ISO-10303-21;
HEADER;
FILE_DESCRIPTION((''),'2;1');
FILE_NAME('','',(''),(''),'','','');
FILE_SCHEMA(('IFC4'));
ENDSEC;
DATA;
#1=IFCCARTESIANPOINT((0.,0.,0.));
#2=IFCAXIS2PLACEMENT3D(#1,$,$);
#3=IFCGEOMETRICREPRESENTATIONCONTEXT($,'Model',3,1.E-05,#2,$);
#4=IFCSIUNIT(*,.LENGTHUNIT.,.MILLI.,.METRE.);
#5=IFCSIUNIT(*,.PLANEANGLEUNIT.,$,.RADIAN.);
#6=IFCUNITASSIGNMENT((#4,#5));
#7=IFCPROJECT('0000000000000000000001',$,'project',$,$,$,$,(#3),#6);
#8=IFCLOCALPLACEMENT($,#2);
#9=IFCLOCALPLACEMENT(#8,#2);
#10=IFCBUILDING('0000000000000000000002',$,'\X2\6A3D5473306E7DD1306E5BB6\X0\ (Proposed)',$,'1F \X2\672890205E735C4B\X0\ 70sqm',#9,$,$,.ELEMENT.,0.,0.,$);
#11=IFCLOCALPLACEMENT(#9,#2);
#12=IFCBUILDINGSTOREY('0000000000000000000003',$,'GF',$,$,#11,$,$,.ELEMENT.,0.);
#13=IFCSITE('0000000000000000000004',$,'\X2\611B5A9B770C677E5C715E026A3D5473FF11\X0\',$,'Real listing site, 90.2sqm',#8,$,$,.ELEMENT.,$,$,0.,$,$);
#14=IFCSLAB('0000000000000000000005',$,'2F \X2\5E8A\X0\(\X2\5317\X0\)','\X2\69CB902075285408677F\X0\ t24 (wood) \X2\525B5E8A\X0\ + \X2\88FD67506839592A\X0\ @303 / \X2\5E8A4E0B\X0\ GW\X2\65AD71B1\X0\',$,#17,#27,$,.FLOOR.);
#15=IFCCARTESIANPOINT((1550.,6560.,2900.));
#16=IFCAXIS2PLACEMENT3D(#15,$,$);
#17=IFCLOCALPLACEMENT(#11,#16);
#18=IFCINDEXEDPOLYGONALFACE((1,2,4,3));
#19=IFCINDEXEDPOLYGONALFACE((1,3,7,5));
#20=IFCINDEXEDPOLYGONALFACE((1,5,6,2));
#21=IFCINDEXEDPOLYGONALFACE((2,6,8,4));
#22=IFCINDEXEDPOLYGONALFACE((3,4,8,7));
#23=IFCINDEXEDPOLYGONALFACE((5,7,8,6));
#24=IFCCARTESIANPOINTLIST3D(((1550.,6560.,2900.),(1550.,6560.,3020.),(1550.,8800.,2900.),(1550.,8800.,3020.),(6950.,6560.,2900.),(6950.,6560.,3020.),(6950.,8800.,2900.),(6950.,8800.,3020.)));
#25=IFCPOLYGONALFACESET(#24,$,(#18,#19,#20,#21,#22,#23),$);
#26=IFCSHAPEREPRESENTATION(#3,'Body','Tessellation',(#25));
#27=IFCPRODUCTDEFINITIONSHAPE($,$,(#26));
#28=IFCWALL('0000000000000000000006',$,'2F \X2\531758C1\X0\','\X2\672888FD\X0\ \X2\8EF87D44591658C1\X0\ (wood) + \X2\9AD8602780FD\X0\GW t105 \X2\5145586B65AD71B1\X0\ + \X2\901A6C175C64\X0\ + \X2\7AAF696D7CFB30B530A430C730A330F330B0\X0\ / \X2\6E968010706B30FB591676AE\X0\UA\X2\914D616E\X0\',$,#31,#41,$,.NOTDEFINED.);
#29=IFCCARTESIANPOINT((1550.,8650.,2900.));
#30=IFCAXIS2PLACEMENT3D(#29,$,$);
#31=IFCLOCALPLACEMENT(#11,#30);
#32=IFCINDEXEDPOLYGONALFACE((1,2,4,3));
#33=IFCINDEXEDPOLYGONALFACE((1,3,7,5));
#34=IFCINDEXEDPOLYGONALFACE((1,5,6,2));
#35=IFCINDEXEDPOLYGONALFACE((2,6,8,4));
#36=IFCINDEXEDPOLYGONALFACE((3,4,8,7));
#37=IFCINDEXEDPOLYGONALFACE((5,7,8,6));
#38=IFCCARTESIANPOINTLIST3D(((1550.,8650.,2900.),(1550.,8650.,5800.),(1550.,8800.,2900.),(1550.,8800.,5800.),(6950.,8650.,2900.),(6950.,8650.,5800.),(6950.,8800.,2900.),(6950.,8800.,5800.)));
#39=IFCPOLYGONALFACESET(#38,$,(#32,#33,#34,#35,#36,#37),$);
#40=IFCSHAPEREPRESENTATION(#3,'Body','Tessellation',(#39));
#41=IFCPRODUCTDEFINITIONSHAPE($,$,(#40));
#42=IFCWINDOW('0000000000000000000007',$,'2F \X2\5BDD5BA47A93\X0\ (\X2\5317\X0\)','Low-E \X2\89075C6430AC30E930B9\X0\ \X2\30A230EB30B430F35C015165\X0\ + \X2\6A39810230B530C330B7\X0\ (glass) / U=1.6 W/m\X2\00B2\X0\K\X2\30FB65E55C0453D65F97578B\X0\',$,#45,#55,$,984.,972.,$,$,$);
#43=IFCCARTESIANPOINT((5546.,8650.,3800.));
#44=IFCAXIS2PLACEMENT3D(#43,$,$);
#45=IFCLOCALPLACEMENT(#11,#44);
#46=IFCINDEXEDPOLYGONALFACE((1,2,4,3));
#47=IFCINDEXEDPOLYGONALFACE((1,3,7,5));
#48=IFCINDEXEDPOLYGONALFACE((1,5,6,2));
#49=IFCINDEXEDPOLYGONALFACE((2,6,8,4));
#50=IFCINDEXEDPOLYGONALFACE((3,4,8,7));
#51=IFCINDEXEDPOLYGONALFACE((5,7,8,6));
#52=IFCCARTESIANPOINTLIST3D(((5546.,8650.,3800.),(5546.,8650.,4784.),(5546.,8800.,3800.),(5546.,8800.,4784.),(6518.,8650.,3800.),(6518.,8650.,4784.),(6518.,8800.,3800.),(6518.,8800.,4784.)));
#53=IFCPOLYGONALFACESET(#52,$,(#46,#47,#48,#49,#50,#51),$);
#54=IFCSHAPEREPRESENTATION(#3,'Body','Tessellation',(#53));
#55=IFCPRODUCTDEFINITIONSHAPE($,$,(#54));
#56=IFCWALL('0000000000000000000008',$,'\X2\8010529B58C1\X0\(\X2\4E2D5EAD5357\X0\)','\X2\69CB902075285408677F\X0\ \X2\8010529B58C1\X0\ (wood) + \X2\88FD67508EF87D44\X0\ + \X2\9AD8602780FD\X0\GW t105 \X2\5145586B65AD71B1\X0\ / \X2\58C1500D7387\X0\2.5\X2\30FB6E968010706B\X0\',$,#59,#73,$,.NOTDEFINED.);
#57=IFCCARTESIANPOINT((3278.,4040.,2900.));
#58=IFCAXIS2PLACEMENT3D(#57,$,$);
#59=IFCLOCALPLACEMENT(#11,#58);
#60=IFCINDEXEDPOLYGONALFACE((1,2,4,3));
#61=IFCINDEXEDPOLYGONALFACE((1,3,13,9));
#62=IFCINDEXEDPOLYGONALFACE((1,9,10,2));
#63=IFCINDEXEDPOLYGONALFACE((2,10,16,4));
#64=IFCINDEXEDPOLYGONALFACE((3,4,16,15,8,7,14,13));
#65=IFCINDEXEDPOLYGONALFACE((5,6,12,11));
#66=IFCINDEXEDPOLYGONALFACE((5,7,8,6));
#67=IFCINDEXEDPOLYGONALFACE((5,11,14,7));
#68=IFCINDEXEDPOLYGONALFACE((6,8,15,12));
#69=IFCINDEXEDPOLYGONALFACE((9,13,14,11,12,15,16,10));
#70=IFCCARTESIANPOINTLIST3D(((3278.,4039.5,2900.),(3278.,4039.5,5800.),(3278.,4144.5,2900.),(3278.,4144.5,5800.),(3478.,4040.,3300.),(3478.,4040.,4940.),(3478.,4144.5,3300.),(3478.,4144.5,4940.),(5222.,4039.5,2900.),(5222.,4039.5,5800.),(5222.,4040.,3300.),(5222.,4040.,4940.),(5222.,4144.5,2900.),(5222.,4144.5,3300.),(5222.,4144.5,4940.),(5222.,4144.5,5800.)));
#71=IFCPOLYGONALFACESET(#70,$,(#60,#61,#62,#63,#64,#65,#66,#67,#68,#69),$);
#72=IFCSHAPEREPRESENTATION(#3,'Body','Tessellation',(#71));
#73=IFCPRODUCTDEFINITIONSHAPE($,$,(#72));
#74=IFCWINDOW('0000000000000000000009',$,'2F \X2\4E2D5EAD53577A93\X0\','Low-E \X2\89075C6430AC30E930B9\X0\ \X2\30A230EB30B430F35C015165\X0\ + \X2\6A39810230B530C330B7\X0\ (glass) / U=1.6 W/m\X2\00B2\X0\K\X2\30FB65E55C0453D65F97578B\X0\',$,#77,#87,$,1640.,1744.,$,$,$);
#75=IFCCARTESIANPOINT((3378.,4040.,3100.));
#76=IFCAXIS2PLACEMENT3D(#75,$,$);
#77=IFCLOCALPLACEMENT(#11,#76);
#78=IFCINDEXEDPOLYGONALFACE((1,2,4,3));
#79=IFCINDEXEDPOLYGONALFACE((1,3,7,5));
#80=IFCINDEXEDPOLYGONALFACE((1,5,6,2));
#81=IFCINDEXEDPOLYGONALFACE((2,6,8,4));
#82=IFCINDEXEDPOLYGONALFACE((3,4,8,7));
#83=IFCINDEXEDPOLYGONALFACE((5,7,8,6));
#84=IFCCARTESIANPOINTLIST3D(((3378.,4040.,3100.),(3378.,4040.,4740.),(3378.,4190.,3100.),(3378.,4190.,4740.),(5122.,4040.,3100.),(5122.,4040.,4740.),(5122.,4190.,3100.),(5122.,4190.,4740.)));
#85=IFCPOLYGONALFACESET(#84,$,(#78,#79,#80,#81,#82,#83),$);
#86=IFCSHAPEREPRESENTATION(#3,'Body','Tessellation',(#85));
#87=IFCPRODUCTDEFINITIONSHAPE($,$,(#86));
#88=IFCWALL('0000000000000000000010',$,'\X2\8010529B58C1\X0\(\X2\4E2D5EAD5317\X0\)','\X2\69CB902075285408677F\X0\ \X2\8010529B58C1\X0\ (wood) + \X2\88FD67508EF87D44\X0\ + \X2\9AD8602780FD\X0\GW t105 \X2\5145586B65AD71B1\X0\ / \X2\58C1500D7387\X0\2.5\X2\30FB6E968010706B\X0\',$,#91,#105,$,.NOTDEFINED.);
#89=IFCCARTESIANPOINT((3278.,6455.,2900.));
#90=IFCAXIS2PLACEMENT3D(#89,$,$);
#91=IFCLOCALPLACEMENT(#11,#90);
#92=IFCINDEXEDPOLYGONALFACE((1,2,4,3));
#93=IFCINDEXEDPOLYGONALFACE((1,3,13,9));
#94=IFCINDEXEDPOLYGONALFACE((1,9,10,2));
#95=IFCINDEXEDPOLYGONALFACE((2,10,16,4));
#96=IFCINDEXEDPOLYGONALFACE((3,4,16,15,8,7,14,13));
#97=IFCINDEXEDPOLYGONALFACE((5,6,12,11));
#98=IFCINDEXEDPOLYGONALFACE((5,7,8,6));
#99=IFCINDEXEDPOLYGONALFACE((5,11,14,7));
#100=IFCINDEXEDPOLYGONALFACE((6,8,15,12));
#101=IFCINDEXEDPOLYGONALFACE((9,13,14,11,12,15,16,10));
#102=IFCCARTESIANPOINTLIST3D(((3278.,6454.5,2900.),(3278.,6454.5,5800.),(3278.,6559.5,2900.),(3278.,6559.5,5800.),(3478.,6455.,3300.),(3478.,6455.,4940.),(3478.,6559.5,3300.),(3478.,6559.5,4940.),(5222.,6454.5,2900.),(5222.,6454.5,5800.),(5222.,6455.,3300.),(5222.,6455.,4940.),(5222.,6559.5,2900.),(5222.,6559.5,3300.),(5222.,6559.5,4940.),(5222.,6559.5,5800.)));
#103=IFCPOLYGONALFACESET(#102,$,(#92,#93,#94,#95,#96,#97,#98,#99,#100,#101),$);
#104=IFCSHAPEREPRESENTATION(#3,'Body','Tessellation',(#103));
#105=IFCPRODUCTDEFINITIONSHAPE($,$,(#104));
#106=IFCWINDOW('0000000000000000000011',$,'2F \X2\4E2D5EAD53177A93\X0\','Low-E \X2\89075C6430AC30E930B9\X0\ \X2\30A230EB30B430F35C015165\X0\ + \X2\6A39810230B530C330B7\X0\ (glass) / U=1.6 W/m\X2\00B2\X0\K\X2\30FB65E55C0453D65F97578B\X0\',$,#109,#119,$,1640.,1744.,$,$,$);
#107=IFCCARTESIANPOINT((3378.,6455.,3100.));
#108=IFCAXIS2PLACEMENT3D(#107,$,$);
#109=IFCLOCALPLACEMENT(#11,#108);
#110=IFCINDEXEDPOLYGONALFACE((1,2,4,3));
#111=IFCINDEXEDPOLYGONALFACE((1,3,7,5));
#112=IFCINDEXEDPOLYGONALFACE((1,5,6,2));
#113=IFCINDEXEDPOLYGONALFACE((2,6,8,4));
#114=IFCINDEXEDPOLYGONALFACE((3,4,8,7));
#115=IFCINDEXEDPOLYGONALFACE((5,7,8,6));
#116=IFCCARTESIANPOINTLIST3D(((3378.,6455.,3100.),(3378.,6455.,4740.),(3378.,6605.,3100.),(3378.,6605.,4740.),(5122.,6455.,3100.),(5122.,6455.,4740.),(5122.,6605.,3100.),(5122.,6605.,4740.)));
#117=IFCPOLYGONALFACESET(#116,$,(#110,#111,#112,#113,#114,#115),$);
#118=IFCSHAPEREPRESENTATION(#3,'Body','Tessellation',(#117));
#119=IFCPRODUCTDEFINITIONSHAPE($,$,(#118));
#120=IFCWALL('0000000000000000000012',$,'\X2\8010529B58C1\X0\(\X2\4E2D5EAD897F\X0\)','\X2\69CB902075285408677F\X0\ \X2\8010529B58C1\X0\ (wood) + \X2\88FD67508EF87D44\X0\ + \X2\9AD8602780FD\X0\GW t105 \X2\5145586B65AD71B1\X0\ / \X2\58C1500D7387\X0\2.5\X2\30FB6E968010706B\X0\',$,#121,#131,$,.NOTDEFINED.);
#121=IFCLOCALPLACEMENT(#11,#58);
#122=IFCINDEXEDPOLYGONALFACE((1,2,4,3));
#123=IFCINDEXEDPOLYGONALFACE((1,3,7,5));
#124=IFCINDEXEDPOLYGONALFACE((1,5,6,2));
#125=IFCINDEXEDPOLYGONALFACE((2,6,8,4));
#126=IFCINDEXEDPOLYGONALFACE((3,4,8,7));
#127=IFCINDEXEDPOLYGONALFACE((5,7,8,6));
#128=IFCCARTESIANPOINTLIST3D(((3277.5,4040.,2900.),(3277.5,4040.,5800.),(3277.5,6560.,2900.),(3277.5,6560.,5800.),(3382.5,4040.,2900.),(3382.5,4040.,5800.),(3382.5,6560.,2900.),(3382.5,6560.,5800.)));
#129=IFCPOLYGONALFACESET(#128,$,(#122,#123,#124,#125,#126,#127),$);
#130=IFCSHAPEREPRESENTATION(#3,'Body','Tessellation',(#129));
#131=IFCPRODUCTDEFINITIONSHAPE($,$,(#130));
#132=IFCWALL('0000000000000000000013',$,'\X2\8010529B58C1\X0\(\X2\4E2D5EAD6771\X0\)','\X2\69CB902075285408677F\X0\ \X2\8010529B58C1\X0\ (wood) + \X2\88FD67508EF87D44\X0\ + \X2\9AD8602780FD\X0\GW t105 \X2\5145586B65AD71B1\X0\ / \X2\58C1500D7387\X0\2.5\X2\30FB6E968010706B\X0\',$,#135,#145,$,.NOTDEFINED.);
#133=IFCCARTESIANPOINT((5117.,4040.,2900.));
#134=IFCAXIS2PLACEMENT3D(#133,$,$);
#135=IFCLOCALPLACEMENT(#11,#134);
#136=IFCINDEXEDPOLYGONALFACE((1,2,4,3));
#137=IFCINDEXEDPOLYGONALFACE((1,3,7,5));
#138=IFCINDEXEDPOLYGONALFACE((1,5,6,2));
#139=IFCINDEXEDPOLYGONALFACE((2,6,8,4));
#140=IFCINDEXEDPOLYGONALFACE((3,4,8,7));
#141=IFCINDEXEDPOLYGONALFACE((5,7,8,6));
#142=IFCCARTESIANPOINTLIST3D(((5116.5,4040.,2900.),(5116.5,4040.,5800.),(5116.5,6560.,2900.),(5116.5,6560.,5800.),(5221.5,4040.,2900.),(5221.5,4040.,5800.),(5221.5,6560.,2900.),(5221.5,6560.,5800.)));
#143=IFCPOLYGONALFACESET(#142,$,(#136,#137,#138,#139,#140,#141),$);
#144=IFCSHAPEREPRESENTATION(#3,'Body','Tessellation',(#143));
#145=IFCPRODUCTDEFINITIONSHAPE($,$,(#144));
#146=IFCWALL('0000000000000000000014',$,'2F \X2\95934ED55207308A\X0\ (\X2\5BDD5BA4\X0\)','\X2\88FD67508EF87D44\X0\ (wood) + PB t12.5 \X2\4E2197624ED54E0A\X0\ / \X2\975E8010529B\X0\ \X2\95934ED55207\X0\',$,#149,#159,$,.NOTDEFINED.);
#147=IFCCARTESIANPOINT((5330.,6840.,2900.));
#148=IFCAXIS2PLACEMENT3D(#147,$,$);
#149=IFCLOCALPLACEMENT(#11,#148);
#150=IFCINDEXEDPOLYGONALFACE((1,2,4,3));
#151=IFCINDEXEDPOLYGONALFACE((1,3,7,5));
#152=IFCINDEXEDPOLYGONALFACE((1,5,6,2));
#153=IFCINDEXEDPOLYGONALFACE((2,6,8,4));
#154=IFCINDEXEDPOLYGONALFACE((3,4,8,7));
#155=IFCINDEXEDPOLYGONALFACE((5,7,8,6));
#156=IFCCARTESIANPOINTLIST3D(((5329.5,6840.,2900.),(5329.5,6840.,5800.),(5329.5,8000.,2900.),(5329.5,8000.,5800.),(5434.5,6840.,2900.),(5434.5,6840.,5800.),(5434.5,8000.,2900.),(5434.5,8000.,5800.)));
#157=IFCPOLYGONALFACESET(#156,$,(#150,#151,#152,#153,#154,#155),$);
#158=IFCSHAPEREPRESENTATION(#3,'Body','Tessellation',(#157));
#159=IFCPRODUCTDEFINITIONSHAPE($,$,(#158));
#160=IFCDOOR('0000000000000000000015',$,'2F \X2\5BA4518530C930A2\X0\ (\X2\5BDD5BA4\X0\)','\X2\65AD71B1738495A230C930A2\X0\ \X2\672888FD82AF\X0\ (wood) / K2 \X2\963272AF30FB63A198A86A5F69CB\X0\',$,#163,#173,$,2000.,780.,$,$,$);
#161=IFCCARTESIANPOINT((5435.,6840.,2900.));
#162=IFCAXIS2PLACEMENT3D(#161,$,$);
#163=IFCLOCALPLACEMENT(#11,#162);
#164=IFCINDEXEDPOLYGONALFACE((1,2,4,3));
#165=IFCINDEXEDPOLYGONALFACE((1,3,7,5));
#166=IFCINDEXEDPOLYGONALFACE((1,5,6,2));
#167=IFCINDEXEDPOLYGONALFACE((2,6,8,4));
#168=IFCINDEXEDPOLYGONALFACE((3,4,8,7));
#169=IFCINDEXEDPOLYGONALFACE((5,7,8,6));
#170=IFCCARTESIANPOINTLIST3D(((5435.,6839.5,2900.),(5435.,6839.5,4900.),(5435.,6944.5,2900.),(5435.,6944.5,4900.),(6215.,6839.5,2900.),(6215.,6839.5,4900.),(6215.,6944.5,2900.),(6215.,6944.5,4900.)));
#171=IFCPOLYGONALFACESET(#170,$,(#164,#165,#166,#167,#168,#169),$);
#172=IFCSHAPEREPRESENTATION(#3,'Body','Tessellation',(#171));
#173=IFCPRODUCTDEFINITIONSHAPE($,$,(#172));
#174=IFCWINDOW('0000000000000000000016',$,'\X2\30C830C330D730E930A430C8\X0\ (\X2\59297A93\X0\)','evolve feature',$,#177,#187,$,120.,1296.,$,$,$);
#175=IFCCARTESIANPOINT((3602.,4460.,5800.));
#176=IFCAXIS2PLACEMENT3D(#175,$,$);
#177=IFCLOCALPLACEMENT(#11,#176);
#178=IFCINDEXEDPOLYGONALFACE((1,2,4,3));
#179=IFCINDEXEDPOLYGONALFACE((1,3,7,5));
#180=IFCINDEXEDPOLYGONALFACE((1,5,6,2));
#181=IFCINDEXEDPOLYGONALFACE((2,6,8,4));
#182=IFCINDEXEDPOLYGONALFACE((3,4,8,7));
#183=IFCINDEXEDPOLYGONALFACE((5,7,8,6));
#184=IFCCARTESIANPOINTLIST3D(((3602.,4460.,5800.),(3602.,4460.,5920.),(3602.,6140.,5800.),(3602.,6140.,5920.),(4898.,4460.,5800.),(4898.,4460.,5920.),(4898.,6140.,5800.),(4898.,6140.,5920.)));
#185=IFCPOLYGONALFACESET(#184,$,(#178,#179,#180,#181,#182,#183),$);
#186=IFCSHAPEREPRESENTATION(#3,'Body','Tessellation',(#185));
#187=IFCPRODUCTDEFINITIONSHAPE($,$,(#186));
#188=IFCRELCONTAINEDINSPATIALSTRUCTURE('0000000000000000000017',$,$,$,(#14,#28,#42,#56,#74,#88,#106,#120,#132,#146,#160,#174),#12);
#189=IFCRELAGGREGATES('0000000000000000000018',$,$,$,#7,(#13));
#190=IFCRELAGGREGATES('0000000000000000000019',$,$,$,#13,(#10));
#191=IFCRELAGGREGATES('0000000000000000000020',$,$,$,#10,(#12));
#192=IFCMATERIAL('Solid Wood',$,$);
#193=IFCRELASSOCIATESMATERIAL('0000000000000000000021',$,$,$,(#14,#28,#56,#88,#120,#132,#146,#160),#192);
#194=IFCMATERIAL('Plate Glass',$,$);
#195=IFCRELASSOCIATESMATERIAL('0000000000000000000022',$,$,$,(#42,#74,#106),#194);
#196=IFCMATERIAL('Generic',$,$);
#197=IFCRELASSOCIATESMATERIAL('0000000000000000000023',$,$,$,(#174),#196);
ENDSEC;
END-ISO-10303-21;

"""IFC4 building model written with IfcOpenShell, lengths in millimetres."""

from ifc_helpers import new_model, si_unit, frame, frame_2d, origin, place, context, project, spatial, rectangle, extrude, material, element, fill, save


model = new_model("IFC4")

# Units and contexts
model_context = context("Model", 3, precision=1e-05, world=origin())
ifc_project = project(units=[si_unit("LENGTHUNIT", "METRE", prefix="MILLI"), si_unit("PLANEANGLEUNIT", "RADIAN")], contexts=[model_context])

# Site, building, storey
site_placement = place(None, origin())
site = spatial("IfcSite", under=ifc_project, at=site_placement, Name="愛媛県松山市樽味１", ObjectType="Real listing site, 90.2sqm", CompositionType="ELEMENT", RefElevation=0.0)
building_placement = place(site_placement, origin())
building = spatial("IfcBuilding", under=site, at=building_placement, Name="樽味の緑の家 (Proposed)", ObjectType="1F 木造平屋 70sqm", CompositionType="ELEMENT", ElevationOfRefHeight=0.0, ElevationOfTerrain=0.0)
storey_placement = place(building_placement, origin())
storey = spatial("IfcBuildingStorey", under=building, at=storey_placement, Name="GF", CompositionType="ELEMENT", Elevation=0.0)

# Slab
ifc_material_1 = material(Name="Solid Wood")
slab_placement = place(storey_placement, frame((1550.0, 6560.0, 2900.0)))
element("IfcSlab", 1, at=slab_placement, inside=storey, material=ifc_material_1, Name="2F 床(北)", Description="構造用合板 t24 (wood) 剛床 + 製材根太 @303 / 床下 GW断熱", PredefinedType="FLOOR", context=model_context, shape_type="SweptSolid", body=[
    extrude(rectangle(XDim=5400.0, YDim=2240.0, at=frame_2d((2700.0, 1120.0))), frame((1550.0, 6560.0, 2900.0)), (0.0, 0.0, 1.0), 120.0),
])

# Walls, openings, windows
wall_1_placement = place(storey_placement, frame((1550.0, 8650.0, 2900.0)))
wall_1 = element("IfcWall", 2, at=wall_1_placement, inside=storey, material=ifc_material_1, Name="2F 北壁", Description="木製 軸組外壁 (wood) + 高性能GW t105 充填断熱 + 通気層 + 窯業系サイディング / 準耐火・外皮UA配慮", PredefinedType="NOTDEFINED", context=model_context, shape_type="SweptSolid", body=[
    extrude(rectangle(XDim=5400.0, YDim=150.0, at=frame_2d((2700.0, 75.0))), frame((1550.0, 8650.0, 2900.0)), (0.0, 0.0, 1.0), 2900.0),
])
opening_1_placement = place(storey_placement, frame((5546.0, 8650.0, 3800.0)))
opening_1 = element("IfcOpeningElement", 3, at=opening_1_placement, cuts=wall_1, PredefinedType="NOTDEFINED", context=model_context, shape_type="SweptSolid", body=[
    extrude(rectangle(XDim=972.0, YDim=150.0, at=frame_2d((486.0, 75.0))), frame((5546.0, 8650.0, 3800.0)), (0.0, 0.0, 1.0), 984.0),
])
ifc_material_2 = material(Name="Plate Glass")
window_1_placement = place(storey_placement, frame((5546.0, 8650.0, 3800.0)))
window_1 = element("IfcWindow", 4, at=window_1_placement, inside=storey, material=ifc_material_2, Name="2F 寝室窓 (北)", Description="Low-E 複層ガラス アルゴン封入 + 樹脂サッシ (glass) / U=1.6 W/m²K・日射取得型", OverallHeight=984.0, OverallWidth=972.0, context=model_context, shape_type="SweptSolid", body=[
    extrude(rectangle(XDim=972.0, YDim=150.0, at=frame_2d((486.0, 75.0))), frame((5546.0, 8650.0, 3800.0)), (0.0, 0.0, 1.0), 984.0),
])
fill(opening_1, window_1)
wall_2_placement = place(storey_placement, frame((3278.0, 4040.0, 2900.0)))
wall_2 = element("IfcWall", 5, at=wall_2_placement, inside=storey, material=ifc_material_1, Name="耐力壁(中庭南)", Description="構造用合板 耐力壁 (wood) + 製材軸組 + 高性能GW t105 充填断熱 / 壁倍率2.5・準耐火", PredefinedType="NOTDEFINED", context=model_context, shape_type="SweptSolid", body=[
    extrude(rectangle(XDim=1944.0, YDim=105.0, at=frame_2d((972.0, 52.0))), frame((3278.0, 4040.0, 2900.0)), (0.0, 0.0, 1.0), 2900.0),
])
opening_2_placement = place(storey_placement, frame((3378.0, 4040.0, 3100.0)))
opening_2 = element("IfcOpeningElement", 6, at=opening_2_placement, cuts=wall_2, PredefinedType="NOTDEFINED", context=model_context, shape_type="SweptSolid", body=[
    extrude(rectangle(XDim=1744.0, YDim=150.0, at=frame_2d((872.0, 75.0))), frame((3378.0, 4040.0, 3100.0)), (0.0, 0.0, 1.0), 1640.0),
])
window_2_placement = place(storey_placement, frame((3378.0, 4040.0, 3100.0)))
window_2 = element("IfcWindow", 7, at=window_2_placement, inside=storey, material=ifc_material_2, Name="2F 中庭南窓", Description="Low-E 複層ガラス アルゴン封入 + 樹脂サッシ (glass) / U=1.6 W/m²K・日射取得型", OverallHeight=1640.0, OverallWidth=1744.0, context=model_context, shape_type="SweptSolid", body=[
    extrude(rectangle(XDim=1744.0, YDim=150.0, at=frame_2d((872.0, 75.0))), frame((3378.0, 4040.0, 3100.0)), (0.0, 0.0, 1.0), 1640.0),
])
fill(opening_2, window_2)
wall_3_placement = place(storey_placement, frame((3278.0, 6455.0, 2900.0)))
wall_3 = element("IfcWall", 8, at=wall_3_placement, inside=storey, material=ifc_material_1, Name="耐力壁(中庭北)", Description="構造用合板 耐力壁 (wood) + 製材軸組 + 高性能GW t105 充填断熱 / 壁倍率2.5・準耐火", PredefinedType="NOTDEFINED", context=model_context, shape_type="SweptSolid", body=[
    extrude(rectangle(XDim=1944.0, YDim=105.0, at=frame_2d((972.0, 52.0))), frame((3278.0, 6455.0, 2900.0)), (0.0, 0.0, 1.0), 2900.0),
])
opening_3_placement = place(storey_placement, frame((3378.0, 6455.0, 3100.0)))
opening_3 = element("IfcOpeningElement", 9, at=opening_3_placement, cuts=wall_3, PredefinedType="NOTDEFINED", context=model_context, shape_type="SweptSolid", body=[
    extrude(rectangle(XDim=1744.0, YDim=150.0, at=frame_2d((872.0, 75.0))), frame((3378.0, 6455.0, 3100.0)), (0.0, 0.0, 1.0), 1640.0),
])
window_3_placement = place(storey_placement, frame((3378.0, 6455.0, 3100.0)))
window_3 = element("IfcWindow", 10, at=window_3_placement, inside=storey, material=ifc_material_2, Name="2F 中庭北窓", Description="Low-E 複層ガラス アルゴン封入 + 樹脂サッシ (glass) / U=1.6 W/m²K・日射取得型", OverallHeight=1640.0, OverallWidth=1744.0, context=model_context, shape_type="SweptSolid", body=[
    extrude(rectangle(XDim=1744.0, YDim=150.0, at=frame_2d((872.0, 75.0))), frame((3378.0, 6455.0, 3100.0)), (0.0, 0.0, 1.0), 1640.0),
])
fill(opening_3, window_3)

# Walls
wall_4_placement = place(storey_placement, frame((3278.0, 4040.0, 2900.0)))
element("IfcWall", 11, at=wall_4_placement, inside=storey, material=ifc_material_1, Name="耐力壁(中庭西)", Description="構造用合板 耐力壁 (wood) + 製材軸組 + 高性能GW t105 充填断熱 / 壁倍率2.5・準耐火", PredefinedType="NOTDEFINED", context=model_context, shape_type="SweptSolid", body=[
    extrude(rectangle(XDim=105.0, YDim=2520.0, at=frame_2d((52.0, 1260.0))), frame((3278.0, 4040.0, 2900.0)), (0.0, 0.0, 1.0), 2900.0),
])
wall_5_placement = place(storey_placement, frame((5117.0, 4040.0, 2900.0)))
element("IfcWall", 12, at=wall_5_placement, inside=storey, material=ifc_material_1, Name="耐力壁(中庭東)", Description="構造用合板 耐力壁 (wood) + 製材軸組 + 高性能GW t105 充填断熱 / 壁倍率2.5・準耐火", PredefinedType="NOTDEFINED", context=model_context, shape_type="SweptSolid", body=[
    extrude(rectangle(XDim=105.0, YDim=2520.0, at=frame_2d((52.0, 1260.0))), frame((5117.0, 4040.0, 2900.0)), (0.0, 0.0, 1.0), 2900.0),
])
wall_6_placement = place(storey_placement, frame((5330.0, 6840.0, 2900.0)))
element("IfcWall", 13, at=wall_6_placement, inside=storey, material=ifc_material_1, Name="2F 間仕切り (寝室)", Description="製材軸組 (wood) + PB t12.5 両面仕上 / 非耐力 間仕切", PredefinedType="NOTDEFINED", context=model_context, shape_type="SweptSolid", body=[
    extrude(rectangle(XDim=105.0, YDim=1160.0, at=frame_2d((52.0, 580.0))), frame((5330.0, 6840.0, 2900.0)), (0.0, 0.0, 1.0), 2900.0),
])

# Door
door_placement = place(storey_placement, frame((5435.0, 6840.0, 2900.0)))
element("IfcDoor", 14, at=door_placement, inside=storey, material=ifc_material_1, Name="2F 室内ドア (寝室)", Description="断熱玄関ドア 木製芯 (wood) / K2 防犯・採風機構", OverallHeight=2000.0, OverallWidth=780.0, context=model_context, shape_type="SweptSolid", body=[
    extrude(rectangle(XDim=780.0, YDim=105.0, at=frame_2d((390.0, 52.0))), frame((5435.0, 6840.0, 2900.0)), (0.0, 0.0, 1.0), 2000.0),
])

# Window
ifc_material_3 = material(Name="Generic")
window_4_placement = place(storey_placement, frame((3602.0, 4460.0, 5800.0)))
element("IfcWindow", 15, at=window_4_placement, inside=storey, material=ifc_material_3, Name="トップライト (天窓)", Description="evolve feature", OverallHeight=120.0, OverallWidth=1296.0, context=model_context, shape_type="SweptSolid", body=[
    extrude(rectangle(XDim=1296.0, YDim=1680.0, at=frame_2d((648.0, 840.0))), frame((3602.0, 4460.0, 5800.0)), (0.0, 0.0, 1.0), 120.0),
])

save(model, "model.ifc")
